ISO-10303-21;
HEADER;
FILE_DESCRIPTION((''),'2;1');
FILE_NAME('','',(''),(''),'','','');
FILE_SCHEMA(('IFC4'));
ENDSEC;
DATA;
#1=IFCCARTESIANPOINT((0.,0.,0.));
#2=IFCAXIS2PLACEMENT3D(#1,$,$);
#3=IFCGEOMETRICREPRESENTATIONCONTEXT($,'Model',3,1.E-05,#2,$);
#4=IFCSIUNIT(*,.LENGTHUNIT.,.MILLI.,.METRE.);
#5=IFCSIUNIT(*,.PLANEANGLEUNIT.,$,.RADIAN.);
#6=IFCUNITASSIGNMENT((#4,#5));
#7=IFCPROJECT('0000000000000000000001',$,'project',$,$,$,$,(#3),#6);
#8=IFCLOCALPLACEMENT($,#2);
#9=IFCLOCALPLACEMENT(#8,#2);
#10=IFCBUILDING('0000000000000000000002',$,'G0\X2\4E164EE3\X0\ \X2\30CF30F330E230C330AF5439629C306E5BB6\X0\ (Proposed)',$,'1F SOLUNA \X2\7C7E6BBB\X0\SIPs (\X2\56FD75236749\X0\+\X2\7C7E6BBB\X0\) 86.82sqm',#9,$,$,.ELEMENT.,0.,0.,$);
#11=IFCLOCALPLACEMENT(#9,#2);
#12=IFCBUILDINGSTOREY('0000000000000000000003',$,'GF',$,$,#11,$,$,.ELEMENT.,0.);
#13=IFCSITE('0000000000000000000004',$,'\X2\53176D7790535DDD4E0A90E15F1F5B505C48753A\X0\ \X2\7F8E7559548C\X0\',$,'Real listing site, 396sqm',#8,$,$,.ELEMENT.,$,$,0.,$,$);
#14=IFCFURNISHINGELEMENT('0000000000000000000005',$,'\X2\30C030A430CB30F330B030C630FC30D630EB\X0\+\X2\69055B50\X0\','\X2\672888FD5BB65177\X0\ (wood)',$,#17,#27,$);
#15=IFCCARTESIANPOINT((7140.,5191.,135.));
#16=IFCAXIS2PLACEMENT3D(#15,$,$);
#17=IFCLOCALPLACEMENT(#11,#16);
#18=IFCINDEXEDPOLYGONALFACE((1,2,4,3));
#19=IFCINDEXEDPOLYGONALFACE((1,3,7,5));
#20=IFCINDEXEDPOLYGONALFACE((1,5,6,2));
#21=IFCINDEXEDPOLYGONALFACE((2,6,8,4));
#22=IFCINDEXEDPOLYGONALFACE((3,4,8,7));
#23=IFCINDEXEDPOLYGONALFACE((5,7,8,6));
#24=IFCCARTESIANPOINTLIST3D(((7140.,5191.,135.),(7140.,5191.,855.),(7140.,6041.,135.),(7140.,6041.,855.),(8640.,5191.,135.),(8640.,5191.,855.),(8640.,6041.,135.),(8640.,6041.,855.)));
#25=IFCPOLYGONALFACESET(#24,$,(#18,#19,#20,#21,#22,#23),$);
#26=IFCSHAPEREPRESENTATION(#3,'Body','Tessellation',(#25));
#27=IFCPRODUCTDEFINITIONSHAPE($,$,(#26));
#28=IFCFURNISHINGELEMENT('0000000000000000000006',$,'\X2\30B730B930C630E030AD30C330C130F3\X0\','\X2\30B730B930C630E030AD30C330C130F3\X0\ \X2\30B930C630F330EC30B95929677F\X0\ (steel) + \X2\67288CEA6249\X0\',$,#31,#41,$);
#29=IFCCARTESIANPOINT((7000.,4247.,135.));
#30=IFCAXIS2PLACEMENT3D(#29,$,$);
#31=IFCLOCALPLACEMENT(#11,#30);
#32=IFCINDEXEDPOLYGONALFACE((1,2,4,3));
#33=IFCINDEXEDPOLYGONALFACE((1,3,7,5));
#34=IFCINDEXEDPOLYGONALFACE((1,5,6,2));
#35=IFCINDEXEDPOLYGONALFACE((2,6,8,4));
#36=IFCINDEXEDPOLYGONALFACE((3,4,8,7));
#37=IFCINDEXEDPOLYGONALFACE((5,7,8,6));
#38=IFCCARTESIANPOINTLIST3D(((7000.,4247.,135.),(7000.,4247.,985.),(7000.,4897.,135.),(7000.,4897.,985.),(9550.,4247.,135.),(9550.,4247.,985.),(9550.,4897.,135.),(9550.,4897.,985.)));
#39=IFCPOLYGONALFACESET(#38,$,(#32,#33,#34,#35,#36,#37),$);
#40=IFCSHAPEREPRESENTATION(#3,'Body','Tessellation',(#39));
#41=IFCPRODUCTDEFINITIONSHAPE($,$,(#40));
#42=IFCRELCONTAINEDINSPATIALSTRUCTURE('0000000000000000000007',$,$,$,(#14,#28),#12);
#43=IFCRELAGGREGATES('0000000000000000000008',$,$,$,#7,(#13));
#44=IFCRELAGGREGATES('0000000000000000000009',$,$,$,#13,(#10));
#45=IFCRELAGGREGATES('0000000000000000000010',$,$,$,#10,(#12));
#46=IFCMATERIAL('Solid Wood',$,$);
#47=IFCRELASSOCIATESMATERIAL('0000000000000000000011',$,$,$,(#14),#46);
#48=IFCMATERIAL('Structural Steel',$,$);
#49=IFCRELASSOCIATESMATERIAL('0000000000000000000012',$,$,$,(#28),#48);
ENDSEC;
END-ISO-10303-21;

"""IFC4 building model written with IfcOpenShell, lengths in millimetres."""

from ifc_helpers import new_model, si_unit, frame, frame_2d, origin, place, context, project, spatial, rectangle, extrude, material, element, save


model = new_model("IFC4")

# Units and contexts
model_context = context("Model", 3, precision=1e-05, world=origin())
ifc_project = project(units=[si_unit("LENGTHUNIT", "METRE", prefix="MILLI"), si_unit("PLANEANGLEUNIT", "RADIAN")], contexts=[model_context])

# Site, building, storey
site_placement = place(None, origin())
site = spatial("IfcSite", under=ifc_project, at=site_placement, Name="北海道川上郡弟子屈町 美留和", ObjectType="Real listing site, 396sqm", CompositionType="ELEMENT", RefElevation=0.0)
building_placement = place(site_placement, origin())
building = spatial("IfcBuilding", under=site, at=building_placement, Name="G0世代 ハンモック吹抜の家 (Proposed)", ObjectType="1F SOLUNA 籾殻SIPs (国産杉+籾殻) 86.82sqm", CompositionType="ELEMENT", ElevationOfRefHeight=0.0, ElevationOfTerrain=0.0)
storey_placement = place(building_placement, origin())
storey = spatial("IfcBuildingStorey", under=building, at=storey_placement, Name="GF", CompositionType="ELEMENT", Elevation=0.0)

# Shared definitions
ifc_material_1 = material(Name="Solid Wood")

# Shared definitions
ifc_material_2 = material(Name="Structural Steel")

# Furnishing elements
furnishing_1_placement = place(storey_placement, frame((7140.0, 5191.0, 135.0)))
element("IfcFurnishingElement", 1, at=furnishing_1_placement, inside=storey, material=ifc_material_1, Name="ダイニングテーブル+椅子", Description="木製家具 (wood)", context=model_context, shape_type="SweptSolid", body=[
    extrude(rectangle(XDim=1500.0, YDim=850.0, at=frame_2d((750.0, 425.0))), frame((7140.0, 5191.0, 135.0)), (0.0, 0.0, 1.0), 720.0),
])
furnishing_2_placement = place(storey_placement, frame((7000.0, 4247.0, 135.0)))
element("IfcFurnishingElement", 2, at=furnishing_2_placement, inside=storey, material=ifc_material_2, Name="システムキッチン", Description="システムキッチン ステンレス天板 (steel) + 木質扉", context=model_context, shape_type="SweptSolid", body=[
    extrude(rectangle(XDim=2550.0, YDim=650.0, at=frame_2d((1275.0, 325.0))), frame((7000.0, 4247.0, 135.0)), (0.0, 0.0, 1.0), 850.0),
])

save(model, "model.ifc")
